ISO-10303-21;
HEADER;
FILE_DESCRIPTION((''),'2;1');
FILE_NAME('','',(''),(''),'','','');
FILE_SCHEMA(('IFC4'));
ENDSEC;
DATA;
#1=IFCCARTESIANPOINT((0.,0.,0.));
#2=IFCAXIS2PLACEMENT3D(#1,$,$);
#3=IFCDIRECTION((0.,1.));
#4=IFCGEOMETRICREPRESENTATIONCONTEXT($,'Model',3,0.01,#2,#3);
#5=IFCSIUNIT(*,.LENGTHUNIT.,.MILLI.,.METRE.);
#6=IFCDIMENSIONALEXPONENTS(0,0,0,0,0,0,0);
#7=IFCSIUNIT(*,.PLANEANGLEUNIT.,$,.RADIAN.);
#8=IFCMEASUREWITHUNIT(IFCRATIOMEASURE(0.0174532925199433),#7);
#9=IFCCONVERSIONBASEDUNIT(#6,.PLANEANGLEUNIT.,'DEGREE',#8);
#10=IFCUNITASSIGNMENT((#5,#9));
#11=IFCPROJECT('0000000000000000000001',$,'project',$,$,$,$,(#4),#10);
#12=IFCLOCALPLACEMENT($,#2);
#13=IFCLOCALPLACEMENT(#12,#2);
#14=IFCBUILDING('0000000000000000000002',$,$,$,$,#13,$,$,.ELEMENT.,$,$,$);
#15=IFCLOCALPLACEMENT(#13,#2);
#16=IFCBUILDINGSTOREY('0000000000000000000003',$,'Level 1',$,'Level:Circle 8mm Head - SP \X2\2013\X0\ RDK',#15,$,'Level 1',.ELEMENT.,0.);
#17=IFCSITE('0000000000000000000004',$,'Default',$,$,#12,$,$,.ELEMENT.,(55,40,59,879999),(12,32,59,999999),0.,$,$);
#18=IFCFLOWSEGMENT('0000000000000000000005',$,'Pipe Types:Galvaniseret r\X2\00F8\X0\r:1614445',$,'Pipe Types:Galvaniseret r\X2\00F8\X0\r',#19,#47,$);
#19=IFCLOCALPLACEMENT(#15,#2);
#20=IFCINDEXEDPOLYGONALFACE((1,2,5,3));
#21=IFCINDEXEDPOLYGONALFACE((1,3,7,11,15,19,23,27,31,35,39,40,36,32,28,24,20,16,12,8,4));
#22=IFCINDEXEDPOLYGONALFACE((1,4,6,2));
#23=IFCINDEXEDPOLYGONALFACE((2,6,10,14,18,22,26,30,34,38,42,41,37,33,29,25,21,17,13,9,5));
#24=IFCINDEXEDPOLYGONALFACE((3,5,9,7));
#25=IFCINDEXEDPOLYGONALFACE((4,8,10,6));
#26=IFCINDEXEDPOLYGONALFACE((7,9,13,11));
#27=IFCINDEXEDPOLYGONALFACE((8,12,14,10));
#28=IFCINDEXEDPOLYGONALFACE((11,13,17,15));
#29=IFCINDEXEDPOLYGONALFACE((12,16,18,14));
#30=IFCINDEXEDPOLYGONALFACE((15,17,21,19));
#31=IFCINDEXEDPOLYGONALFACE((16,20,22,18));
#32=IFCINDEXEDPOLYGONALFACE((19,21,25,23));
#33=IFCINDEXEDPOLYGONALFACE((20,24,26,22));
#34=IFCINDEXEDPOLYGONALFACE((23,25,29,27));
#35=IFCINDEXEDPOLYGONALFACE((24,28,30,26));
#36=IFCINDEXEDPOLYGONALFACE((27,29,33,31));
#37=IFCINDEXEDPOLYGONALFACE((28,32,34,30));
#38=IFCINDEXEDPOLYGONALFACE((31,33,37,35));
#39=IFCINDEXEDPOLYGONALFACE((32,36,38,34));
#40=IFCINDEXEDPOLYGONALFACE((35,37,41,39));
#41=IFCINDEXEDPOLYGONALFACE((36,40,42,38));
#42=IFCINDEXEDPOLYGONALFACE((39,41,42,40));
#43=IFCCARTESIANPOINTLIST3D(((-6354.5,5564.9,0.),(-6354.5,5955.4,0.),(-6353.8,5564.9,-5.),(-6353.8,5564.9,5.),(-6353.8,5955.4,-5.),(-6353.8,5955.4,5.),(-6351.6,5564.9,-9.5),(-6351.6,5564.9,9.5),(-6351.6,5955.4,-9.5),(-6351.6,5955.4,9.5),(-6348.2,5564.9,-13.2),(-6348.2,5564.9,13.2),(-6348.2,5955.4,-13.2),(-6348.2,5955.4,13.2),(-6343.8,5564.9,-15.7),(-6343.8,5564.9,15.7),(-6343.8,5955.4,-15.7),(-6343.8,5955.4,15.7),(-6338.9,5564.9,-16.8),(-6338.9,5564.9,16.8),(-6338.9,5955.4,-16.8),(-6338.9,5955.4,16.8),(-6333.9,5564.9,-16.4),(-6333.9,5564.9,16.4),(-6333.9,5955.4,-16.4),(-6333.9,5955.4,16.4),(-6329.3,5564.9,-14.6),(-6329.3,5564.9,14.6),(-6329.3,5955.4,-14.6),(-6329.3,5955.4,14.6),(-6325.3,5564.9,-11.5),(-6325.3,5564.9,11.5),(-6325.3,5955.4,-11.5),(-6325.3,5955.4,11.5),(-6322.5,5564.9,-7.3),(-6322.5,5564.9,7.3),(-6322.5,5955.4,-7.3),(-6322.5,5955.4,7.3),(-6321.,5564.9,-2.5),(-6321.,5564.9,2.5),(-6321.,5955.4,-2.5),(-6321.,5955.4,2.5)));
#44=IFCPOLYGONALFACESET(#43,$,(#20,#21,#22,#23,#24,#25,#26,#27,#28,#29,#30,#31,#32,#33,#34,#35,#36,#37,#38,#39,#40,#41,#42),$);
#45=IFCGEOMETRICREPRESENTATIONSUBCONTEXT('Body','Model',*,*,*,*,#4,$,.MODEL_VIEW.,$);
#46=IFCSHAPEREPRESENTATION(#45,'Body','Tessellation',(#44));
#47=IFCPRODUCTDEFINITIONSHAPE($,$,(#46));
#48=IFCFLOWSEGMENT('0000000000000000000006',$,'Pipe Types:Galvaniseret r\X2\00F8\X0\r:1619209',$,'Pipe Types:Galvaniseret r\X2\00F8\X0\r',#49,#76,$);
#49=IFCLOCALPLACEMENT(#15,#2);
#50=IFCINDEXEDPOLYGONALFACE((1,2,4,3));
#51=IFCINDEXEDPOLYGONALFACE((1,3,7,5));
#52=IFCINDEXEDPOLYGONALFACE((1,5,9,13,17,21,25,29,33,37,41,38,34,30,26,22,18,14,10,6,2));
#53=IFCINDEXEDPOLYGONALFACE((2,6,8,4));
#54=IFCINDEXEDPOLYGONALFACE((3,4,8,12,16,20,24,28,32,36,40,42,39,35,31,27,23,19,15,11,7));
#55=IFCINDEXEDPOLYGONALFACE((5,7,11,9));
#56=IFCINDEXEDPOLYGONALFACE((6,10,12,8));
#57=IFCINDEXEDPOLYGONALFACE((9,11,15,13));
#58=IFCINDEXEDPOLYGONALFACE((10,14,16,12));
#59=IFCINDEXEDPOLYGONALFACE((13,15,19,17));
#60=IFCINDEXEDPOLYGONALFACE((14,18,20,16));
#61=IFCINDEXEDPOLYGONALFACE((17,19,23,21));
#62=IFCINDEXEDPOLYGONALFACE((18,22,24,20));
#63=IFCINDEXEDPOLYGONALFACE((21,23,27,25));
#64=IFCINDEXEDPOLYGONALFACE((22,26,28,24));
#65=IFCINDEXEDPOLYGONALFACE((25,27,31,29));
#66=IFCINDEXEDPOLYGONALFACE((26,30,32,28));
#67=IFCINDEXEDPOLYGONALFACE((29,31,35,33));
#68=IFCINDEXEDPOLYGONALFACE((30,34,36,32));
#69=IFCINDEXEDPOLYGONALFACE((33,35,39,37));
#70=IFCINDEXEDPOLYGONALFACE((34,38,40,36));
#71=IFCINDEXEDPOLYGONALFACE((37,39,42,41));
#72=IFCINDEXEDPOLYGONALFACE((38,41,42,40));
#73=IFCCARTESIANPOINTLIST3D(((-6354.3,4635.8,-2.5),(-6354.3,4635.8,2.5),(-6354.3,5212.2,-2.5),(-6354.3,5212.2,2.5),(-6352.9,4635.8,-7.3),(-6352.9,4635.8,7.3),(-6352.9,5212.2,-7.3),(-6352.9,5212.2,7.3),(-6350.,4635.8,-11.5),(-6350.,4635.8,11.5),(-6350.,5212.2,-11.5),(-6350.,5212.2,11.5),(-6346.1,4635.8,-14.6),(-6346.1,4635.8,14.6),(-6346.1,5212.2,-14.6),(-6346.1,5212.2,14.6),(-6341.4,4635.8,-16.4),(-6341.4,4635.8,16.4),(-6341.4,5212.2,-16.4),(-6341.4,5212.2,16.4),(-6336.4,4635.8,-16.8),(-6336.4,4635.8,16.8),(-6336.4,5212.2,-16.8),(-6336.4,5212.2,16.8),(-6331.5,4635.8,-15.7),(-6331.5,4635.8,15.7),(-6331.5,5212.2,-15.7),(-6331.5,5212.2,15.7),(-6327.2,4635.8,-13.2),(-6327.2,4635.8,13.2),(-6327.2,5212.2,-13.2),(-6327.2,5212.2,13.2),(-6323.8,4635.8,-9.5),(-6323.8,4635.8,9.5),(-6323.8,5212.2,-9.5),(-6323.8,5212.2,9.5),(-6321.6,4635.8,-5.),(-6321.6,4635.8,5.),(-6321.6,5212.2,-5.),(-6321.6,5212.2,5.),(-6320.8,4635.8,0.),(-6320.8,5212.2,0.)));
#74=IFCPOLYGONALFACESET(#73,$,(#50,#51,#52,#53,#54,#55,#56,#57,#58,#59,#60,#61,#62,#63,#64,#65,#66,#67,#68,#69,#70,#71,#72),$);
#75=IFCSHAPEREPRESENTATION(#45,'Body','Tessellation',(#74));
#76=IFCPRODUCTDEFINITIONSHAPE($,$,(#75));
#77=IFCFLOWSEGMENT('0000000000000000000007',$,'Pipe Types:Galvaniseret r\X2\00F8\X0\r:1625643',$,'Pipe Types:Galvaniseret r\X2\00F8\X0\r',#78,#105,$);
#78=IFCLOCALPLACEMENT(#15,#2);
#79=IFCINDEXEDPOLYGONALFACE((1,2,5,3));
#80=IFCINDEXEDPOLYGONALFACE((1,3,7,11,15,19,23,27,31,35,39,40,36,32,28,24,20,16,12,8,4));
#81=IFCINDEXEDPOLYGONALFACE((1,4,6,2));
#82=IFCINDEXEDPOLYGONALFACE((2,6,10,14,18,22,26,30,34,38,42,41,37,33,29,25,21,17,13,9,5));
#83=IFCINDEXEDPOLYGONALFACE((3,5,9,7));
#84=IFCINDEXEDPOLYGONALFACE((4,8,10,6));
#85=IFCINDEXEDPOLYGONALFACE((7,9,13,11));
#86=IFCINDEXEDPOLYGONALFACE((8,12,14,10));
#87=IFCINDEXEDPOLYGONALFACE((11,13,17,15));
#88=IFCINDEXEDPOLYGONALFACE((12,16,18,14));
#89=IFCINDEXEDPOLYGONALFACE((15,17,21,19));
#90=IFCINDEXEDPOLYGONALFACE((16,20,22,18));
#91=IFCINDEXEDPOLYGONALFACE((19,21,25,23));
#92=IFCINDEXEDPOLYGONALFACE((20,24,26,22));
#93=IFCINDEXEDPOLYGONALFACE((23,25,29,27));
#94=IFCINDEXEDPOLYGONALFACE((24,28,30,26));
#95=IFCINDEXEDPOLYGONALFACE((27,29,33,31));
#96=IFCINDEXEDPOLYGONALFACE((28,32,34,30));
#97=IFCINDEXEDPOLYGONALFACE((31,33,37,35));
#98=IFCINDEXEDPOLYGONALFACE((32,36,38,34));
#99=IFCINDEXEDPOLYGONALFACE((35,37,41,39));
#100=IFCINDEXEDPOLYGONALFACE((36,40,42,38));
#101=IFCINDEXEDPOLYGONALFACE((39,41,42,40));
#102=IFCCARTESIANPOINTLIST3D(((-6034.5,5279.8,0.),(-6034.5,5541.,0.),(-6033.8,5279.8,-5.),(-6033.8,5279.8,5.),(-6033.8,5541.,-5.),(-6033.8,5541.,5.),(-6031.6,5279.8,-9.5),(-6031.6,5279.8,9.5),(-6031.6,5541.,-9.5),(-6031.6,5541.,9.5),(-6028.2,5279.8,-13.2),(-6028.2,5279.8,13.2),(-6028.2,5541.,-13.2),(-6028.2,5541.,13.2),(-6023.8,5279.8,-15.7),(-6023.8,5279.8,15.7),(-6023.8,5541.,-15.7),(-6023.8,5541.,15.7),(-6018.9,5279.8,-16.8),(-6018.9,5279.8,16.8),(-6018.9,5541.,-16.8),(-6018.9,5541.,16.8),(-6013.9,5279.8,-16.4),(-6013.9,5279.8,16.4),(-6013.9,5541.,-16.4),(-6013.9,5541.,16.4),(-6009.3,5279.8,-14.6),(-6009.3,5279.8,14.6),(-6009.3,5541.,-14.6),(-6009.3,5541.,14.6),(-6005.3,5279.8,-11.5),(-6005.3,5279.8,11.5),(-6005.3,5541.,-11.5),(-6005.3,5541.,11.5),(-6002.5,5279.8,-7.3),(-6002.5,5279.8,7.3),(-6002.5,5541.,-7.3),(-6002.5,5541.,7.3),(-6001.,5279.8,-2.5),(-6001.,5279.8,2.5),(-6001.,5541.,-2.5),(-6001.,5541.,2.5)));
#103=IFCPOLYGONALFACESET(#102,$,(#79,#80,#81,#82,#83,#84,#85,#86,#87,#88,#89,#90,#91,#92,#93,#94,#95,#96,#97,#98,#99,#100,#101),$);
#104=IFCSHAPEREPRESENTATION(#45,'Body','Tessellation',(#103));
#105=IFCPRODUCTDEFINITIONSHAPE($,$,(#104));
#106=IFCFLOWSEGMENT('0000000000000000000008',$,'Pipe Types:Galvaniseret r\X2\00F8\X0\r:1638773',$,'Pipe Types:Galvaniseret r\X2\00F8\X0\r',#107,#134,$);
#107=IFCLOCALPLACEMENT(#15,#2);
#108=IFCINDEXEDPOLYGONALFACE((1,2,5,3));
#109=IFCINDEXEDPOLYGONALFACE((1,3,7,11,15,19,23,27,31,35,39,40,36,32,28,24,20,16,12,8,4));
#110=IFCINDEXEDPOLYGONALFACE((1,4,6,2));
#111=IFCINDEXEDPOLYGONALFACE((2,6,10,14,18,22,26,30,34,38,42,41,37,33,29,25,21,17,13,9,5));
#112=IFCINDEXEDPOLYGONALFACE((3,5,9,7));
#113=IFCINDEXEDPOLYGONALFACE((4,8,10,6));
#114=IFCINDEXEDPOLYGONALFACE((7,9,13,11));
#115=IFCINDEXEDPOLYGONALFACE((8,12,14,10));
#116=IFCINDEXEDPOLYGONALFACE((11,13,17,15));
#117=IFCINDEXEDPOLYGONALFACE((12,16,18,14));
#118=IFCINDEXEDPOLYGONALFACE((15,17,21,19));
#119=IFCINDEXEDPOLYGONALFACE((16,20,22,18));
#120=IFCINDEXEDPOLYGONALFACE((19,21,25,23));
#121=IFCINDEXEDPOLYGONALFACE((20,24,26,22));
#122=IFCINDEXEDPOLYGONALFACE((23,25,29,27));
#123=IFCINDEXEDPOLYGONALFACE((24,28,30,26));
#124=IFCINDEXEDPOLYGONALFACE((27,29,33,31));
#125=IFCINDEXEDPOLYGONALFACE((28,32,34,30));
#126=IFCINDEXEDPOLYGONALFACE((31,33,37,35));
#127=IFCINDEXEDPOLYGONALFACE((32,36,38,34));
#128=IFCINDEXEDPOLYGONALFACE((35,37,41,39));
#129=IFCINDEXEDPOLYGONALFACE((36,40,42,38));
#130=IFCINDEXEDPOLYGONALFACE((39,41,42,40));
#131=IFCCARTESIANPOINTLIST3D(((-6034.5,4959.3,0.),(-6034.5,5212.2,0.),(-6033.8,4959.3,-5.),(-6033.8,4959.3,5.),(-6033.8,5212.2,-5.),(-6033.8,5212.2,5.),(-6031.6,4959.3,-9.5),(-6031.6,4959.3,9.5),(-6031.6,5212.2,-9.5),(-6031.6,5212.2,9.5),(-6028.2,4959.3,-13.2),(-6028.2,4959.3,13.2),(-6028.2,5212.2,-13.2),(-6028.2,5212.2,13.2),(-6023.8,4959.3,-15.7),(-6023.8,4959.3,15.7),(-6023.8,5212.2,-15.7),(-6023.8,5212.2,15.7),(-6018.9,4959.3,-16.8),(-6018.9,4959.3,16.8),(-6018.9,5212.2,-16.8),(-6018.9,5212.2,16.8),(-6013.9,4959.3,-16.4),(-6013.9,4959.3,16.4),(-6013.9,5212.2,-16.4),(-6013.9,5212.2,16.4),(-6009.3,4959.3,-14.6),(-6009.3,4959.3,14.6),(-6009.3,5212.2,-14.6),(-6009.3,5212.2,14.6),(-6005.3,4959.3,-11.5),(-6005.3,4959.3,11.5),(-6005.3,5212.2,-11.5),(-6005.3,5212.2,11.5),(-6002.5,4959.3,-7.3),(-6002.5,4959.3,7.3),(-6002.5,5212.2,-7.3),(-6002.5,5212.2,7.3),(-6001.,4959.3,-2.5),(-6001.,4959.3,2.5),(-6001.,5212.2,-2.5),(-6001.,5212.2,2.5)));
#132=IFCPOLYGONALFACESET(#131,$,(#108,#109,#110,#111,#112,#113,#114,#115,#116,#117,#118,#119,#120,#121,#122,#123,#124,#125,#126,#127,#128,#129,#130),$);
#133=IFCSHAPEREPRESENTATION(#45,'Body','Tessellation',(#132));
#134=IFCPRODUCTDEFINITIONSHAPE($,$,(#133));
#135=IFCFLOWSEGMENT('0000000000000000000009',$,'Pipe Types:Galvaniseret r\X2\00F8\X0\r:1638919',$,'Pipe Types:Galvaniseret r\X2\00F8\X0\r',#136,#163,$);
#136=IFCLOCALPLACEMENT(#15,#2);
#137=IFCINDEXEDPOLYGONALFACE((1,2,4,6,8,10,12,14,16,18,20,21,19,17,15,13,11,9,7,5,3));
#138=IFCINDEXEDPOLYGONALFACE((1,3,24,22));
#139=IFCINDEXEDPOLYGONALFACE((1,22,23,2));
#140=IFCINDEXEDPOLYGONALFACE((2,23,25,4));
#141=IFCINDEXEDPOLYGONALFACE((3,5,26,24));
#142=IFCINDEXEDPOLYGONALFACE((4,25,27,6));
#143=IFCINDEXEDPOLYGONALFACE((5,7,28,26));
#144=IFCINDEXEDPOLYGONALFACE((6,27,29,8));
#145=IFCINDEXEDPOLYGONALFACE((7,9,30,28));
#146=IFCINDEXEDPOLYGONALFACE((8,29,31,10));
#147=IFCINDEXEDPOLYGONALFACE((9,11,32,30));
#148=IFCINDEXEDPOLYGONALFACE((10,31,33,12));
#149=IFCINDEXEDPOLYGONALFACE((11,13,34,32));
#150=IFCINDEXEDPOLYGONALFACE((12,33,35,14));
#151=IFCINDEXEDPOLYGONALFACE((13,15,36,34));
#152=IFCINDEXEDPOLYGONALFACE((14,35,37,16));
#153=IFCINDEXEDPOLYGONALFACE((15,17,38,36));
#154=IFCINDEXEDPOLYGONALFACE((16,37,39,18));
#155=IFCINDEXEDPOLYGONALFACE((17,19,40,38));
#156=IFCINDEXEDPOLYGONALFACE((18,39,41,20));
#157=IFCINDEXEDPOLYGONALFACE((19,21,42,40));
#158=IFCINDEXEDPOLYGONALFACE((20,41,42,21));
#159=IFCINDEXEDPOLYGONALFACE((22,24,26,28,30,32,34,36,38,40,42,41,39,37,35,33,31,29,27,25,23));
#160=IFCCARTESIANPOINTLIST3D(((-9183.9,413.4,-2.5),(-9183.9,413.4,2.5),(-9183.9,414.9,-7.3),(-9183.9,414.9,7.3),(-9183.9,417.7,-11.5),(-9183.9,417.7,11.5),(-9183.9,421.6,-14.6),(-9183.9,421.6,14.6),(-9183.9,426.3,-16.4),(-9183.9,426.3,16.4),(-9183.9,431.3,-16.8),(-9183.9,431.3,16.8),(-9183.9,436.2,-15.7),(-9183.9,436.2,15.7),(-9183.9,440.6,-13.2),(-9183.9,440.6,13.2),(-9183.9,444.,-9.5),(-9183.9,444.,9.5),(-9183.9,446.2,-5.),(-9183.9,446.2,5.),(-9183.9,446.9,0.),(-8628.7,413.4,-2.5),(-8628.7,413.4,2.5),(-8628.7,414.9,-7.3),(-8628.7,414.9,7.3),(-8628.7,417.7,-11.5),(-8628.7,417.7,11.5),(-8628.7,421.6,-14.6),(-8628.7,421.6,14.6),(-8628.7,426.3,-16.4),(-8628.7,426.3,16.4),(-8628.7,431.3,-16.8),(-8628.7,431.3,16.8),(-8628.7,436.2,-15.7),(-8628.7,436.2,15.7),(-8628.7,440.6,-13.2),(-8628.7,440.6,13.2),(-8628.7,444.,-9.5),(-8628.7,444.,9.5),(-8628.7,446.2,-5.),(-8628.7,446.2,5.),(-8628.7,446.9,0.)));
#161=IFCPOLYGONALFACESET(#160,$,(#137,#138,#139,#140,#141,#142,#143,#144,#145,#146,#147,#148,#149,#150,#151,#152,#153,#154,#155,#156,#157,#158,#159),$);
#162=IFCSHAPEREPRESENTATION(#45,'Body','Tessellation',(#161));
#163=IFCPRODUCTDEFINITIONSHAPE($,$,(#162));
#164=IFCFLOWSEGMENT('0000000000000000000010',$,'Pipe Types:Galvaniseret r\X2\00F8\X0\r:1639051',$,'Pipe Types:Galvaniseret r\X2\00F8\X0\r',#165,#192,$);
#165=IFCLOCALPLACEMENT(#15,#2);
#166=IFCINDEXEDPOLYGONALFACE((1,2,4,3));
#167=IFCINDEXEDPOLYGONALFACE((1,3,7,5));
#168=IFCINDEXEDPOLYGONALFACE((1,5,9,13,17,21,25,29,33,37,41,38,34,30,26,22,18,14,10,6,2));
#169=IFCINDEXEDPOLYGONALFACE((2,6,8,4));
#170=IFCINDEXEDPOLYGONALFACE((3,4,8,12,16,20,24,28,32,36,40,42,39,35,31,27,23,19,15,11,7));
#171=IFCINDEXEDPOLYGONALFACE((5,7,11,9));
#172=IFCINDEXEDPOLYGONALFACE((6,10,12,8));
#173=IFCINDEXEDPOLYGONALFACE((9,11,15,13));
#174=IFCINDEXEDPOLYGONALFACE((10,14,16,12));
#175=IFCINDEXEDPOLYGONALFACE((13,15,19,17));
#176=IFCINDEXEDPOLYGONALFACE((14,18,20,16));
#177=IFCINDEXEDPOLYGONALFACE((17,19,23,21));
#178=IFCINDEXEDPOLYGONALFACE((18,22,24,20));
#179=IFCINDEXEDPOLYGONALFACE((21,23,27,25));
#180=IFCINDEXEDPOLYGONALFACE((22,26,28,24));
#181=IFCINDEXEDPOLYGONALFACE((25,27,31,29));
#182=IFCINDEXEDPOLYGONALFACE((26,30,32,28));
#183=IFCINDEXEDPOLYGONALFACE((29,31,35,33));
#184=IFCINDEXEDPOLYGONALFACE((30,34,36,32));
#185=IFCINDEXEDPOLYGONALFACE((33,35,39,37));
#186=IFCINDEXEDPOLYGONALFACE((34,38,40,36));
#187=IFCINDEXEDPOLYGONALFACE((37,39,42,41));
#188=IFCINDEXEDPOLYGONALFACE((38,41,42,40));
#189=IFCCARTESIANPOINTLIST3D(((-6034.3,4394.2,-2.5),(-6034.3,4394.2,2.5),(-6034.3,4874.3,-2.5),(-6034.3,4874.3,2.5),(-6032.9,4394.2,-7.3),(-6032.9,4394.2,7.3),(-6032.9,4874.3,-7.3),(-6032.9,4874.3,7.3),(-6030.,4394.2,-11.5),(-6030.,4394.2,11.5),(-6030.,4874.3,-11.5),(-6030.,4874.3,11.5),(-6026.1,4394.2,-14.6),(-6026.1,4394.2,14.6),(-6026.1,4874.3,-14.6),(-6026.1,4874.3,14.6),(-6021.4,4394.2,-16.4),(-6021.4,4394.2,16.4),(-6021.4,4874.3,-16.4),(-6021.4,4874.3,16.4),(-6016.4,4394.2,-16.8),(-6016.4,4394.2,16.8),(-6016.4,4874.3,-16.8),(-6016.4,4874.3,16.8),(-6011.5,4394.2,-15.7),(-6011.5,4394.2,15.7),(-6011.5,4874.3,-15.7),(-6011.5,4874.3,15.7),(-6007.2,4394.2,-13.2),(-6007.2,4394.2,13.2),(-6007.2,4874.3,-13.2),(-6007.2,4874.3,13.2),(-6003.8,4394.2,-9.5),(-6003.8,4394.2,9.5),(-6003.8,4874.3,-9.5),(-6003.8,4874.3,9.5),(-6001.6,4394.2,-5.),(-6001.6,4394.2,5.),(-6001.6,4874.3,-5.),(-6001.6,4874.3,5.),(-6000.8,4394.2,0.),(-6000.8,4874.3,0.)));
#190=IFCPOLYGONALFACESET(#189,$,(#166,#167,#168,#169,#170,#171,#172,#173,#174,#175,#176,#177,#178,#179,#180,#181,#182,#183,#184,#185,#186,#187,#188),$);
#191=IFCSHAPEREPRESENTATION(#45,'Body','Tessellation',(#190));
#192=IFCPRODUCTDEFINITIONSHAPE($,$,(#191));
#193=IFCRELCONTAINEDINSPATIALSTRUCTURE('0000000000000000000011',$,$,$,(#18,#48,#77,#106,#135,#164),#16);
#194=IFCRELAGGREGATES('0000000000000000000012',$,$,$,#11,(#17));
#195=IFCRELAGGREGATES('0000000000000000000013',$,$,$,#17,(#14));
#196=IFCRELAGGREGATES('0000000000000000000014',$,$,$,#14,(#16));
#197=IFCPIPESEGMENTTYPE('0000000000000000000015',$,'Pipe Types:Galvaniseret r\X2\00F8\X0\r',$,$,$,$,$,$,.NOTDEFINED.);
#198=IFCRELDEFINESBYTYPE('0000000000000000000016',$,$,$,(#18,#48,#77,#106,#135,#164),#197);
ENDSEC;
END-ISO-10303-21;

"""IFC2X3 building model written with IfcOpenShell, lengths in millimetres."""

from ifc_helpers import new_model, entity, si_unit, converted_unit, direction, frame, frame_2d, origin, place, context, subcontext, project, spatial, circle, extrude, type_object, element, save


model = new_model("IFC2X3")

# Units and contexts
model_context = context("Model", 3, precision=0.01, world=origin(), true_north=direction((0.0, 1.0)))
body_context = subcontext(model_context, "Body", "Model", "MODEL_VIEW")
ifc_project = project(units=[si_unit("LENGTHUNIT", "METRE", prefix="MILLI"), converted_unit("PLANEANGLEUNIT", "DEGREE", entity("IfcRatioMeasure", 0.0174532925199433), si_unit("PLANEANGLEUNIT", "RADIAN"), dimensions=[0, 0, 0, 0, 0, 0, 0])], contexts=[model_context])

# Site, building, storey
site_placement = place(None, origin())
site = spatial("IfcSite", under=ifc_project, at=site_placement, Name="Default", CompositionType="ELEMENT", RefLatitude=(55, 40, 59, 879999), RefLongitude=(12, 32, 59, 999999), RefElevation=0.0)
building_placement = place(site_placement, origin())
building = spatial("IfcBuilding", under=site, at=building_placement, CompositionType="ELEMENT")
storey_placement = place(building_placement, origin())
storey = spatial("IfcBuildingStorey", under=building, at=storey_placement, Name="Level 1", ObjectType="Level:Circle 8mm Head - SP – RDK", LongName="Level 1", CompositionType="ELEMENT", Elevation=0.0)

# Flow segments
pipe_segment_type = type_object("IfcPipeSegmentType", Name="Pipe Types:Galvaniseret rør", PredefinedType="NOTDEFINED")
flow_segment_1_placement = place(storey_placement, origin())
element("IfcFlowSegment", 1, at=flow_segment_1_placement, inside=storey, type_object=pipe_segment_type, Name="Pipe Types:Galvaniseret rør:1614445", ObjectType="Pipe Types:Galvaniseret rør", context=body_context, shape_type="SweptSolid", body=[
    extrude(circle(Radius=16.9, at=frame_2d((0.0, 0.0), x_axis=(1.0, 0.0))), frame((-6337.7, 5564.9, 0.0), z_axis=(0.0, 1.0, 0.0), x_axis=(-1.0, 0.0, 0.0)), (0.0, 0.0, 1.0), 390.5),
])
flow_segment_2_placement = place(storey_placement, origin())
element("IfcFlowSegment", 2, at=flow_segment_2_placement, inside=storey, type_object=pipe_segment_type, Name="Pipe Types:Galvaniseret rør:1619209", ObjectType="Pipe Types:Galvaniseret rør", context=body_context, shape_type="SweptSolid", body=[
    extrude(circle(Radius=16.9, at=frame_2d((0.0, 0.0), x_axis=(1.0, 0.0))), frame((-6337.7, 4635.8, 0.0), z_axis=(0.0, 1.0, 0.0), x_axis=(1.0, 0.0, 0.0)), (0.0, 0.0, 1.0), 576.4),
])
flow_segment_3_placement = place(storey_placement, origin())
element("IfcFlowSegment", 3, at=flow_segment_3_placement, inside=storey, type_object=pipe_segment_type, Name="Pipe Types:Galvaniseret rør:1625643", ObjectType="Pipe Types:Galvaniseret rør", context=body_context, shape_type="SweptSolid", body=[
    extrude(circle(Radius=16.9, at=frame_2d((0.0, 0.0), x_axis=(1.0, 0.0))), frame((-6017.7, 5279.8, 0.0), z_axis=(0.0, 1.0, 0.0), x_axis=(-1.0, 0.0, 0.0)), (0.0, 0.0, 1.0), 261.2),
])
flow_segment_4_placement = place(storey_placement, origin())
element("IfcFlowSegment", 4, at=flow_segment_4_placement, inside=storey, type_object=pipe_segment_type, Name="Pipe Types:Galvaniseret rør:1638773", ObjectType="Pipe Types:Galvaniseret rør", context=body_context, shape_type="SweptSolid", body=[
    extrude(circle(Radius=16.9, at=frame_2d((0.0, 0.0), x_axis=(1.0, 0.0))), frame((-6017.7, 4959.3, 0.0), z_axis=(0.0, 1.0, 0.0), x_axis=(-1.0, 0.0, 0.0)), (0.0, 0.0, 1.0), 252.9),
])
flow_segment_5_placement = place(storey_placement, origin())
element("IfcFlowSegment", 5, at=flow_segment_5_placement, inside=storey, type_object=pipe_segment_type, Name="Pipe Types:Galvaniseret rør:1638919", ObjectType="Pipe Types:Galvaniseret rør", context=body_context, shape_type="SweptSolid", body=[
    extrude(circle(Radius=16.9, at=frame_2d((0.0, 0.0), x_axis=(1.0, 0.0))), frame((-9183.9, 430.1, 0.0), z_axis=(1.0, 0.0, 0.0), x_axis=(0.0, 1.0, 0.0)), (0.0, 0.0, 1.0), 555.2),
])
flow_segment_6_placement = place(storey_placement, origin())
element("IfcFlowSegment", 6, at=flow_segment_6_placement, inside=storey, type_object=pipe_segment_type, Name="Pipe Types:Galvaniseret rør:1639051", ObjectType="Pipe Types:Galvaniseret rør", context=body_context, shape_type="SweptSolid", body=[
    extrude(circle(Radius=16.9, at=frame_2d((0.0, 0.0), x_axis=(1.0, 0.0))), frame((-6017.7, 4394.2, 0.0), z_axis=(0.0, 1.0, 0.0), x_axis=(1.0, 0.0, 0.0)), (0.0, 0.0, 1.0), 480.1),
])

save(model, "model.ifc")
